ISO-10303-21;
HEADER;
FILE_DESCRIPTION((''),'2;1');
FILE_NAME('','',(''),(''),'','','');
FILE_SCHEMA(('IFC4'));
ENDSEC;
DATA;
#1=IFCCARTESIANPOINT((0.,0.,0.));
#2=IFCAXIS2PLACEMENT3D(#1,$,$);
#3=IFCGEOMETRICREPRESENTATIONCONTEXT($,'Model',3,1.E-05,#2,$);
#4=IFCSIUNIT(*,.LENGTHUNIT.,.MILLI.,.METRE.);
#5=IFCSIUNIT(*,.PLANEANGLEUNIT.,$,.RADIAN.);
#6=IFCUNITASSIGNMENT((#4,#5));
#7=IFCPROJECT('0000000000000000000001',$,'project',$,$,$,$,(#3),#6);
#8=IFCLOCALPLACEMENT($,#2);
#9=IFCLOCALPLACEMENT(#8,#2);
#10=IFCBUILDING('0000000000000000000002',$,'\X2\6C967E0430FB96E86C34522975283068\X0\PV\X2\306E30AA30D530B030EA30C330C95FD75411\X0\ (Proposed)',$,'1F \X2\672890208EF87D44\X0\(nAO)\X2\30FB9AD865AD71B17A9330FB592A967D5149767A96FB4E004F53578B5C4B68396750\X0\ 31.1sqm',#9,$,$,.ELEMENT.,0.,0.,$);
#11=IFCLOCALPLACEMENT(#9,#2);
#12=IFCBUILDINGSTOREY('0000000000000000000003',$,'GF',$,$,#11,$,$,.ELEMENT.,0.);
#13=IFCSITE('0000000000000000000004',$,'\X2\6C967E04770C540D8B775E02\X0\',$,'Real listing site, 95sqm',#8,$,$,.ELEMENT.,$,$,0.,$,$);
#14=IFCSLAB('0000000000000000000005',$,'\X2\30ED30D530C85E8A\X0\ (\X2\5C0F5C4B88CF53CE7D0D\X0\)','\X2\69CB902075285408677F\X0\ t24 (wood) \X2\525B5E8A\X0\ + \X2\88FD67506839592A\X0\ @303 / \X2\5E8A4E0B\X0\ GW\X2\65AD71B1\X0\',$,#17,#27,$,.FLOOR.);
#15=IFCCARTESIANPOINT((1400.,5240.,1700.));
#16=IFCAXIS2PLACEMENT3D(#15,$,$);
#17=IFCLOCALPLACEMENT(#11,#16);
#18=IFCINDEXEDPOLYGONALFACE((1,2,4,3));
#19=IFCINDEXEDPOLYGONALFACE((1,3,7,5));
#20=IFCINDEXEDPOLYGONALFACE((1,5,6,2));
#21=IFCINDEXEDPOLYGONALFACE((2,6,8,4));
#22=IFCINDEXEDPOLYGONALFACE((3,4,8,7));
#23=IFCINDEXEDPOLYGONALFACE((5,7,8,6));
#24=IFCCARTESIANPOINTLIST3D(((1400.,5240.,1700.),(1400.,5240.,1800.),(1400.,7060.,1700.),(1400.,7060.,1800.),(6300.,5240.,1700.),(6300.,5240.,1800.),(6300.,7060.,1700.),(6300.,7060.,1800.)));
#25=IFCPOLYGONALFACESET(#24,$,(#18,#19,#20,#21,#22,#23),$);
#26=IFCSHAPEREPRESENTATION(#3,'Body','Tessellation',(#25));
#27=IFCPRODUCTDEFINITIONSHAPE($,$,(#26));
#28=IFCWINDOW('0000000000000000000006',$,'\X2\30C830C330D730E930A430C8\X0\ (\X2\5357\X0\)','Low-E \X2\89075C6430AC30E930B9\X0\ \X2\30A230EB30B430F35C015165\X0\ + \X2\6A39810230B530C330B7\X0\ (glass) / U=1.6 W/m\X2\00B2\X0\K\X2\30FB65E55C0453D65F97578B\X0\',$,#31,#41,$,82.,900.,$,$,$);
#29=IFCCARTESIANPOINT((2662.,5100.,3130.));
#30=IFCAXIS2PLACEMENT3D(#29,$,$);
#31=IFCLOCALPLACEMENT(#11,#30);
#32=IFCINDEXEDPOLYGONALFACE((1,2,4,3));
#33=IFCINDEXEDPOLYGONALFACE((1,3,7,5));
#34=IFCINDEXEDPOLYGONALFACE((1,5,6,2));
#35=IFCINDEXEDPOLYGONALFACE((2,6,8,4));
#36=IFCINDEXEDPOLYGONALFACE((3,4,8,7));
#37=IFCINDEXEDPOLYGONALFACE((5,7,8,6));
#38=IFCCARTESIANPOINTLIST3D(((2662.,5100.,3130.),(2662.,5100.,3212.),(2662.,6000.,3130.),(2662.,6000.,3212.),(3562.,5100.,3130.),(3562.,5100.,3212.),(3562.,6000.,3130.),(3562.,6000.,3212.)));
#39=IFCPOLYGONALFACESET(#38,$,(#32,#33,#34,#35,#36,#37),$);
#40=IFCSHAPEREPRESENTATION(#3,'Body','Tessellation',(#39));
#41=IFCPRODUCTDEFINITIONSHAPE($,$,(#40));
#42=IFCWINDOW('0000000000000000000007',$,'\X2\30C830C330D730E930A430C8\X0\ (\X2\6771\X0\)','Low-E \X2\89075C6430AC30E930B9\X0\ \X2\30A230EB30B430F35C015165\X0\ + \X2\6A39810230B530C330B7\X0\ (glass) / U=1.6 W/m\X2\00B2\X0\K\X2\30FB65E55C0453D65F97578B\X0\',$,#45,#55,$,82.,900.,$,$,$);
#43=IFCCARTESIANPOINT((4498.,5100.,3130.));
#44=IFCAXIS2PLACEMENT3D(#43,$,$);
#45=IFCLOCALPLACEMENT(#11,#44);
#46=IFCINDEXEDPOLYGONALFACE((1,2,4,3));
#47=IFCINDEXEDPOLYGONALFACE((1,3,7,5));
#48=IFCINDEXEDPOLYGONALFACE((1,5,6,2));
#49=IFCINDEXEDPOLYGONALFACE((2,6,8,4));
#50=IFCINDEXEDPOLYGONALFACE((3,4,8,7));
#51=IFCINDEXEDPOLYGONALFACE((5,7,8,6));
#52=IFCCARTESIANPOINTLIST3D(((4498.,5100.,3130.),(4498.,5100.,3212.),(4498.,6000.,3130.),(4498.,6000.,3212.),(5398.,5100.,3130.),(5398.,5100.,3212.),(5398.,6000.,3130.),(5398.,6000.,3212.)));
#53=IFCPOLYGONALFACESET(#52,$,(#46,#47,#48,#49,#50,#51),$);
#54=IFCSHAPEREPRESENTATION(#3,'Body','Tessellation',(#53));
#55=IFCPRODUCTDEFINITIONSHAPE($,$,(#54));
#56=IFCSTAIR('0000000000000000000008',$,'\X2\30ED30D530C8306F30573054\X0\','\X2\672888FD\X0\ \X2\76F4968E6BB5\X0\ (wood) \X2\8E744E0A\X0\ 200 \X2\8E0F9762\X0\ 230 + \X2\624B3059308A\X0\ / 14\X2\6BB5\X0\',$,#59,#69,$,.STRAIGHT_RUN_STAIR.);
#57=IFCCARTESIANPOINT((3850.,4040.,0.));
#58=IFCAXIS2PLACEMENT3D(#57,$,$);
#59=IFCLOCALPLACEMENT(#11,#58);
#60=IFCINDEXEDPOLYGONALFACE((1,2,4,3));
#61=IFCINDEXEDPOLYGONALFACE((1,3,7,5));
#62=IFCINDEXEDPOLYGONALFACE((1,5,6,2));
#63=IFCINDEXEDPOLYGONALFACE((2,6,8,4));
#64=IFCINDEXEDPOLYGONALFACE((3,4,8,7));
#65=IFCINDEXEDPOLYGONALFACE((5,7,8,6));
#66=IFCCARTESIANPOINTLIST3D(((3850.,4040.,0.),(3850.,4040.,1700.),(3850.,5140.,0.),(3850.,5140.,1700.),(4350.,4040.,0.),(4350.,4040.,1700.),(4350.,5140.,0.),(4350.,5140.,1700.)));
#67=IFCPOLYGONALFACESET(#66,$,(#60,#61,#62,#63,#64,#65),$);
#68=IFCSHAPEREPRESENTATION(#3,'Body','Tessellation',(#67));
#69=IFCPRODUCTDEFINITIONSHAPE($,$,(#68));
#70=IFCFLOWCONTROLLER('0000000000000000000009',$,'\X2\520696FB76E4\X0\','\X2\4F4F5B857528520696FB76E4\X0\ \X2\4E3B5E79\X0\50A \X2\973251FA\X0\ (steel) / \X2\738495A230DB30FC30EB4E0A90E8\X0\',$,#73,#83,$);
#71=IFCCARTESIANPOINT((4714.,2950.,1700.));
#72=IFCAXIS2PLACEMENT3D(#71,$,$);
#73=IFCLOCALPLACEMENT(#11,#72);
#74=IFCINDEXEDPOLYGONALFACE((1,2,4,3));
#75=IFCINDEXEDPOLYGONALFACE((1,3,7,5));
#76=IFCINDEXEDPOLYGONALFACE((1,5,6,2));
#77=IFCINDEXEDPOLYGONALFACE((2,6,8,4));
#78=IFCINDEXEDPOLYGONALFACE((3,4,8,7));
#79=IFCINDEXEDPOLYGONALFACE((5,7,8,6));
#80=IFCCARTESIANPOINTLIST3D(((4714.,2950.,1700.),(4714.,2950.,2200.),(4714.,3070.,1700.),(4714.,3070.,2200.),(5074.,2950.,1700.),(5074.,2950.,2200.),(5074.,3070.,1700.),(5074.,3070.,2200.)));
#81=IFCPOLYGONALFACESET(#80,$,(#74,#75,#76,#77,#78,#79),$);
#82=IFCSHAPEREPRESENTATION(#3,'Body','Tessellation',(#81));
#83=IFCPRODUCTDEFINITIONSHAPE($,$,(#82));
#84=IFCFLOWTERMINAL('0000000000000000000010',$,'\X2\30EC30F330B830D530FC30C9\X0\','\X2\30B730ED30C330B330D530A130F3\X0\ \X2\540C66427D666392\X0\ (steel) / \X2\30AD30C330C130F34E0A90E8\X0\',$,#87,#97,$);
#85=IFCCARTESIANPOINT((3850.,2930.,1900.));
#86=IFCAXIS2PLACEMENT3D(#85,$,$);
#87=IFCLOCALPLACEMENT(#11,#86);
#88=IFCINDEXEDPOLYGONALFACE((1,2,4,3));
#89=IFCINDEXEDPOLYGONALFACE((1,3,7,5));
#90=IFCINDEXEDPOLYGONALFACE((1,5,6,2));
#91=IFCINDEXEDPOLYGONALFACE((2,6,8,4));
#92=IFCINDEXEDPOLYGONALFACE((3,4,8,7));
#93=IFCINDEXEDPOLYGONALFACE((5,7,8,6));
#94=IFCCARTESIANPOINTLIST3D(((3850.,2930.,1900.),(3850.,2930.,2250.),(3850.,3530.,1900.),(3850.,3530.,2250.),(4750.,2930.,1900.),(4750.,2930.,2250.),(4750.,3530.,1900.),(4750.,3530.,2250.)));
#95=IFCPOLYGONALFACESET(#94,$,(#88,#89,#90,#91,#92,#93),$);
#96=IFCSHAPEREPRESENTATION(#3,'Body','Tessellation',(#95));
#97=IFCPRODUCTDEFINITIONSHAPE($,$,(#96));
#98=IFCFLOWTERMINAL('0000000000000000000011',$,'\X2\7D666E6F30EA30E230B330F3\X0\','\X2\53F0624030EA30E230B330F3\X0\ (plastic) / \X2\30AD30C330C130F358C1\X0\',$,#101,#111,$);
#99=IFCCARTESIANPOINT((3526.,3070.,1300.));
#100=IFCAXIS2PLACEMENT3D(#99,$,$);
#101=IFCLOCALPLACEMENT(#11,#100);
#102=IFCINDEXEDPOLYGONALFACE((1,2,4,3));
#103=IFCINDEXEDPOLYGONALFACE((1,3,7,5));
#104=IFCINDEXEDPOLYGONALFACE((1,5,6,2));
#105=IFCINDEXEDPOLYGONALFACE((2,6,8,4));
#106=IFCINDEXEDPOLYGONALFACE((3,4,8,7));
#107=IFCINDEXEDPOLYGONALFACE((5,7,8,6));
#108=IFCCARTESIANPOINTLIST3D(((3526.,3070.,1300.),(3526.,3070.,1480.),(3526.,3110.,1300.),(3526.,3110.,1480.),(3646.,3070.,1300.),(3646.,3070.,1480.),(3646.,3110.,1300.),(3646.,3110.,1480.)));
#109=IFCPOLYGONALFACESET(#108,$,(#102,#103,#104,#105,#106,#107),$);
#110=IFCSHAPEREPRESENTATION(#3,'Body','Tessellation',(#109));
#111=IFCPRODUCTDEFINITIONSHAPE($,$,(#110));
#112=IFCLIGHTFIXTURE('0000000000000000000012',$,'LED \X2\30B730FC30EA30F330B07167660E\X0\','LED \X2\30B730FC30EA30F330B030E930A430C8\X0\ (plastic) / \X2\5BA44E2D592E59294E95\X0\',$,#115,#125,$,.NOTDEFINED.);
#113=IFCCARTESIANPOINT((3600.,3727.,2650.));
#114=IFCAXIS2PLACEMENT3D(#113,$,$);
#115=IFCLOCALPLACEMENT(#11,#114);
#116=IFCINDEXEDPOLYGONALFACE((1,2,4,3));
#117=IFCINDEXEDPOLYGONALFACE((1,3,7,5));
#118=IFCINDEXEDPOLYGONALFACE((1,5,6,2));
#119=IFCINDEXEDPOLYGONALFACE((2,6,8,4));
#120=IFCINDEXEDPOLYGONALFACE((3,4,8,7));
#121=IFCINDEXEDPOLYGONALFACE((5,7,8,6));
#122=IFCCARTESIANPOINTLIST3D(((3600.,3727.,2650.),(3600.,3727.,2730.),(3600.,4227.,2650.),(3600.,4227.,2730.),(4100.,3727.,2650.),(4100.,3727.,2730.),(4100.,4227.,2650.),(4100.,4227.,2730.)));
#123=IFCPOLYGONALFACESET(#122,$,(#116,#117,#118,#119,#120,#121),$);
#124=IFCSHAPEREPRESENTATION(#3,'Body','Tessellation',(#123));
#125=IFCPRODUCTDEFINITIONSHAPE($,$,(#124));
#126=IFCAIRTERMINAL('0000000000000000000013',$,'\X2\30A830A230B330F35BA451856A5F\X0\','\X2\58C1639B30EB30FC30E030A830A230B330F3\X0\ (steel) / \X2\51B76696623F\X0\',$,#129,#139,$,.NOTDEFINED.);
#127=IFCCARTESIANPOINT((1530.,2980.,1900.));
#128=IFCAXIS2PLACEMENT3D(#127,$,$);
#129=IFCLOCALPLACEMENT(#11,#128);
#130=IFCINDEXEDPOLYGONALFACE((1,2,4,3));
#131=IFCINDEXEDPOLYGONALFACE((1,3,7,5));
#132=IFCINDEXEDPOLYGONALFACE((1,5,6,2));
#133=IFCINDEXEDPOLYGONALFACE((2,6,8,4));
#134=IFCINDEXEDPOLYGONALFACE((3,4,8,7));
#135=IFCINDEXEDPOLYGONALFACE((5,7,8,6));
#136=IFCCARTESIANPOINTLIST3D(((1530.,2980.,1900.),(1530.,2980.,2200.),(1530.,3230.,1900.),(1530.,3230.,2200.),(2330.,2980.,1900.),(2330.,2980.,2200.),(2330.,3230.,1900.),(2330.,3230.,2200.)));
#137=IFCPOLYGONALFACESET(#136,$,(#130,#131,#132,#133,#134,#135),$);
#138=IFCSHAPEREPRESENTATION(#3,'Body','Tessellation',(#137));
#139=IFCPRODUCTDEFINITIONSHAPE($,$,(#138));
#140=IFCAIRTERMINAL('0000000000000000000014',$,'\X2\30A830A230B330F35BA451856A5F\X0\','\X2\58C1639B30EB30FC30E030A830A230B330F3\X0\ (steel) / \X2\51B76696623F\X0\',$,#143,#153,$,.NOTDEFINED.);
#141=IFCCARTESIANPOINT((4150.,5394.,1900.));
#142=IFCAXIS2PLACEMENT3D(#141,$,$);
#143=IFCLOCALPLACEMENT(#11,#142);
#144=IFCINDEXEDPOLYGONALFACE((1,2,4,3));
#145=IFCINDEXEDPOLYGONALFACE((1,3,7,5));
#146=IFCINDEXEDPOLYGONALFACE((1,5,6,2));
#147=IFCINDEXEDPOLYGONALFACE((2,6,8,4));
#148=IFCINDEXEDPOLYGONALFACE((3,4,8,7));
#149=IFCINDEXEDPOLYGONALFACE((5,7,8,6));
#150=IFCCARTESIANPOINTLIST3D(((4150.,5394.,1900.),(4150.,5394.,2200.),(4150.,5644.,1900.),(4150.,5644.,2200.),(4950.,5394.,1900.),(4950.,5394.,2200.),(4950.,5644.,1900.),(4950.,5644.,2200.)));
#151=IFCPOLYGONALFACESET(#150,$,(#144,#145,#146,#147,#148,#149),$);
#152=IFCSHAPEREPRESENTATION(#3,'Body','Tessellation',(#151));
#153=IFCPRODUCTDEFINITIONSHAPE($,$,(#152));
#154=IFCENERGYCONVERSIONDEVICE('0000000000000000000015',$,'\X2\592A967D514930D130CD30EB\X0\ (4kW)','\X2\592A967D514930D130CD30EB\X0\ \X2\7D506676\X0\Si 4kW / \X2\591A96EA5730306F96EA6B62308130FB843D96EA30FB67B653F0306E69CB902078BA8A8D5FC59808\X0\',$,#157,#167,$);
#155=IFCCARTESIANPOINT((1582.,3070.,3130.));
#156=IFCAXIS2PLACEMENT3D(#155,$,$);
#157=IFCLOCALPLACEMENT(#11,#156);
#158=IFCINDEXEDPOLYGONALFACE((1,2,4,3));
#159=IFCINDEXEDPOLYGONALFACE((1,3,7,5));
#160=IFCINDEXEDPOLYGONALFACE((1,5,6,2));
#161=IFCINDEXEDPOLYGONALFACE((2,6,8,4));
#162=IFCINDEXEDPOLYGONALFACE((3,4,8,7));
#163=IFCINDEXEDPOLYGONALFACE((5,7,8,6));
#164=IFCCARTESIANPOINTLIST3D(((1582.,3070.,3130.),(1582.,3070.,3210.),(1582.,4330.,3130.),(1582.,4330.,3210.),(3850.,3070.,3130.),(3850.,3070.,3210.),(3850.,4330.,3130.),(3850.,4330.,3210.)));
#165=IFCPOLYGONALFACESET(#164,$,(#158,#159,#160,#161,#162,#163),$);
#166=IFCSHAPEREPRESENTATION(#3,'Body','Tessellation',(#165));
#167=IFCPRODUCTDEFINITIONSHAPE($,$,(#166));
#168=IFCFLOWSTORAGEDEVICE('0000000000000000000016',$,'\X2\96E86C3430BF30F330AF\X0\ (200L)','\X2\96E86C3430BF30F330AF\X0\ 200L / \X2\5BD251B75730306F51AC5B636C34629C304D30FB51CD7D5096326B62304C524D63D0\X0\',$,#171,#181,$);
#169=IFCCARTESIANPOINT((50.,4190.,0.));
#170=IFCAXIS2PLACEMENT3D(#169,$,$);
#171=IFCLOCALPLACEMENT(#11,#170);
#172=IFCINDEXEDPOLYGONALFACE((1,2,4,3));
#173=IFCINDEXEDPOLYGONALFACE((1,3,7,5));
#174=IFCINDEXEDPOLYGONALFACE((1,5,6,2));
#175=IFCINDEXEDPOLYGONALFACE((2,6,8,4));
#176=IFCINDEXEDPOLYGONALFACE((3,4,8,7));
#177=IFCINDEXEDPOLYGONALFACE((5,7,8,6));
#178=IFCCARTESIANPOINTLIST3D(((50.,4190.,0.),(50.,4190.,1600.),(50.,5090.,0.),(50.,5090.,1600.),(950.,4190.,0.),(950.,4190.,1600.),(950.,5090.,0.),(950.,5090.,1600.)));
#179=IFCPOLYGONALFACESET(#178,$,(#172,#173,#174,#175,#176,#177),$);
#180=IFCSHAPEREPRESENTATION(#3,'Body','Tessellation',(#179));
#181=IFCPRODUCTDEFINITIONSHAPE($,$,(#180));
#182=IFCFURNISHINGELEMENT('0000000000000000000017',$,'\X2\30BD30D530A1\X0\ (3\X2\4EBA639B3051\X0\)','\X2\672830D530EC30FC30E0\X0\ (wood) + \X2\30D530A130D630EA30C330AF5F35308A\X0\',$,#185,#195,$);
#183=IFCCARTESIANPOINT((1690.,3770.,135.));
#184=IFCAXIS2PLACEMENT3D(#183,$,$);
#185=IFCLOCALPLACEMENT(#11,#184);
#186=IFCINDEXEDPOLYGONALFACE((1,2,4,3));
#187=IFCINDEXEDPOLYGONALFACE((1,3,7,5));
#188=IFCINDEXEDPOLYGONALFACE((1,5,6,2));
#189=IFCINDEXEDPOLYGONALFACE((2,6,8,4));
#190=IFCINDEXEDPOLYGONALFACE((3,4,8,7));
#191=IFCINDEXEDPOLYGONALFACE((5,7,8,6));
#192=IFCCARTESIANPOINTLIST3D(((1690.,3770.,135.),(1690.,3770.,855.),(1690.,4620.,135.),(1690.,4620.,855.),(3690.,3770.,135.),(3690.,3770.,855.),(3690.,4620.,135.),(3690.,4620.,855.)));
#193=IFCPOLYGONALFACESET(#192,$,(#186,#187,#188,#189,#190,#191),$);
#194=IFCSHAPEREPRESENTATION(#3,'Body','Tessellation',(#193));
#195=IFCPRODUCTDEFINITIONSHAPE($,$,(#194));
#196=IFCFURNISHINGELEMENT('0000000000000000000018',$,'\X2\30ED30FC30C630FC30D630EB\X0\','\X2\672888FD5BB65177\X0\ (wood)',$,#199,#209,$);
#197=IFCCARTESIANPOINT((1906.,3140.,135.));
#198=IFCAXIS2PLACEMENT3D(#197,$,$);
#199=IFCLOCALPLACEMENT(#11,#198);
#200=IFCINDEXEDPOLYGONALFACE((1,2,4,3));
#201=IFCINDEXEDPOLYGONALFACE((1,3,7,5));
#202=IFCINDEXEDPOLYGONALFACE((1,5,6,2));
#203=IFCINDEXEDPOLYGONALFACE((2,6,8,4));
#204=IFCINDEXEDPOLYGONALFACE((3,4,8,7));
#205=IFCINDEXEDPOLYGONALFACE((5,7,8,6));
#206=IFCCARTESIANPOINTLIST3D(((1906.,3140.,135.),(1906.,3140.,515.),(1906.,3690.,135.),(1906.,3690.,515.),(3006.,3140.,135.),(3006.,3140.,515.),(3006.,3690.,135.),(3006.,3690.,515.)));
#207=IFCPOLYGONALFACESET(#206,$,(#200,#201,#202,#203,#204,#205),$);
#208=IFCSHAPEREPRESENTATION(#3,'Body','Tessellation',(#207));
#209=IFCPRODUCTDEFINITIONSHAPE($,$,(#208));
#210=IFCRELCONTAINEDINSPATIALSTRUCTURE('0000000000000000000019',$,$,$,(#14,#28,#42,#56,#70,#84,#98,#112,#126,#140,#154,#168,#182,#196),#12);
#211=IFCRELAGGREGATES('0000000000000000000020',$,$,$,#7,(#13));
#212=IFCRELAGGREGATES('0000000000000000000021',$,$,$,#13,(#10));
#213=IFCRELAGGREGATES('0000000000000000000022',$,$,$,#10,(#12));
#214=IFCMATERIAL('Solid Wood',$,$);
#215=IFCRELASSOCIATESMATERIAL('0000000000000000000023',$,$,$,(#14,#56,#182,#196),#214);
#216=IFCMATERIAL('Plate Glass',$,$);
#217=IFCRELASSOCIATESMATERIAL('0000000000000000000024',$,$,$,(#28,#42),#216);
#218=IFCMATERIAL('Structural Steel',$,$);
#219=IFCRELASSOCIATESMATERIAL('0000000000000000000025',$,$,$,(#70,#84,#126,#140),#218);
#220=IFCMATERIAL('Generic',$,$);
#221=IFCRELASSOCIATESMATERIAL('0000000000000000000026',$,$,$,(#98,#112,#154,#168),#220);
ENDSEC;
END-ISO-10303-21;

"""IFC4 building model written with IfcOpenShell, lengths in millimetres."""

from ifc_helpers import new_model, si_unit, frame, frame_2d, origin, place, context, project, spatial, rectangle, extrude, material, element, save


model = new_model("IFC4")

# Units and contexts
model_context = context("Model", 3, precision=1e-05, world=origin())
ifc_project = project(units=[si_unit("LENGTHUNIT", "METRE", prefix="MILLI"), si_unit("PLANEANGLEUNIT", "RADIAN")], contexts=[model_context])

# Site, building, storey
site_placement = place(None, origin())
site = spatial("IfcSite", under=ifc_project, at=site_placement, Name="沖縄県名護市", ObjectType="Real listing site, 95sqm", CompositionType="ELEMENT", RefElevation=0.0)
building_placement = place(site_placement, origin())
building = spatial("IfcBuilding", under=site, at=building_placement, Name="沖縄・雨水利用とPVのオフグリッド志向 (Proposed)", ObjectType="1F 木造軸組(nAO)・高断熱窓・太陽光発電一体型屋根材 31.1sqm", CompositionType="ELEMENT", ElevationOfRefHeight=0.0, ElevationOfTerrain=0.0)
storey_placement = place(building_placement, origin())
storey = spatial("IfcBuildingStorey", under=building, at=storey_placement, Name="GF", CompositionType="ELEMENT", Elevation=0.0)

# Shared definitions
ifc_material_1 = material(Name="Solid Wood")

# Slab
slab_placement = place(storey_placement, frame((1400.0, 5240.0, 1700.0)))
element("IfcSlab", 1, at=slab_placement, inside=storey, material=ifc_material_1, Name="ロフト床 (小屋裏収納)", Description="構造用合板 t24 (wood) 剛床 + 製材根太 @303 / 床下 GW断熱", PredefinedType="FLOOR", context=model_context, shape_type="SweptSolid", body=[
    extrude(rectangle(XDim=4900.0, YDim=1820.0, at=frame_2d((2450.0, 910.0))), frame((1400.0, 5240.0, 1700.0)), (0.0, 0.0, 1.0), 100.0),
])

# Windows
ifc_material_2 = material(Name="Plate Glass")
window_1_placement = place(storey_placement, frame((2662.0, 5100.0, 3130.0)))
element("IfcWindow", 2, at=window_1_placement, inside=storey, material=ifc_material_2, Name="トップライト (南)", Description="Low-E 複層ガラス アルゴン封入 + 樹脂サッシ (glass) / U=1.6 W/m²K・日射取得型", OverallHeight=82.0, OverallWidth=900.0, context=model_context, shape_type="SweptSolid", body=[
    extrude(rectangle(XDim=900.0, YDim=900.0, at=frame_2d((450.0, 450.0))), frame((2662.0, 5100.0, 3130.0)), (0.0, 0.0, 1.0), 82.0),
])
window_2_placement = place(storey_placement, frame((4498.0, 5100.0, 3130.0)))
element("IfcWindow", 3, at=window_2_placement, inside=storey, material=ifc_material_2, Name="トップライト (東)", Description="Low-E 複層ガラス アルゴン封入 + 樹脂サッシ (glass) / U=1.6 W/m²K・日射取得型", OverallHeight=82.0, OverallWidth=900.0, context=model_context, shape_type="SweptSolid", body=[
    extrude(rectangle(XDim=900.0, YDim=900.0, at=frame_2d((450.0, 450.0))), frame((4498.0, 5100.0, 3130.0)), (0.0, 0.0, 1.0), 82.0),
])

# Stair
stair_placement = place(storey_placement, frame((3850.0, 4040.0, 0.0)))
element("IfcStair", 4, at=stair_placement, inside=storey, material=ifc_material_1, Name="ロフトはしご", Description="木製 直階段 (wood) 蹴上 200 踏面 230 + 手すり / 14段", PredefinedType="STRAIGHT_RUN_STAIR", context=model_context, shape_type="SweptSolid", body=[
    extrude(rectangle(XDim=500.0, YDim=1100.0, at=frame_2d((250.0, 550.0))), frame((3850.0, 4040.0, 0.0)), (0.0, 0.0, 1.0), 1700.0),
])

# Flow controller
ifc_material_3 = material(Name="Structural Steel")
flow_controller_placement = place(storey_placement, frame((4714.0, 2950.0, 1700.0)))
element("IfcFlowController", 5, at=flow_controller_placement, inside=storey, material=ifc_material_3, Name="分電盤", Description="住宅用分電盤 主幹50A 露出 (steel) / 玄関ホール上部", context=model_context, shape_type="SweptSolid", body=[
    extrude(rectangle(XDim=360.0, YDim=120.0, at=frame_2d((180.0, 60.0))), frame((4714.0, 2950.0, 1700.0)), (0.0, 0.0, 1.0), 500.0),
])

# Flow terminals
flow_terminal_1_placement = place(storey_placement, frame((3850.0, 2930.0, 1900.0)))
element("IfcFlowTerminal", 6, at=flow_terminal_1_placement, inside=storey, material=ifc_material_3, Name="レンジフード", Description="シロッコファン 同時給排 (steel) / キッチン上部", context=model_context, shape_type="SweptSolid", body=[
    extrude(rectangle(XDim=900.0, YDim=600.0, at=frame_2d((450.0, 300.0))), frame((3850.0, 2930.0, 1900.0)), (0.0, 0.0, 1.0), 350.0),
])
ifc_material_4 = material(Name="Generic")
flow_terminal_2_placement = place(storey_placement, frame((3526.0, 3070.0, 1300.0)))
element("IfcFlowTerminal", 7, at=flow_terminal_2_placement, inside=storey, material=ifc_material_4, Name="給湯リモコン", Description="台所リモコン (plastic) / キッチン壁", context=model_context, shape_type="SweptSolid", body=[
    extrude(rectangle(XDim=120.0, YDim=40.0, at=frame_2d((60.0, 20.0))), frame((3526.0, 3070.0, 1300.0)), (0.0, 0.0, 1.0), 180.0),
])

# Light fixture
light_fixture_placement = place(storey_placement, frame((3600.0, 3727.0, 2650.0)))
element("IfcLightFixture", 8, at=light_fixture_placement, inside=storey, material=ifc_material_4, Name="LED シーリング照明", Description="LED シーリングライト (plastic) / 室中央天井", PredefinedType="NOTDEFINED", context=model_context, shape_type="SweptSolid", body=[
    extrude(rectangle(XDim=500.0, YDim=500.0, at=frame_2d((250.0, 250.0))), frame((3600.0, 3727.0, 2650.0)), (0.0, 0.0, 1.0), 80.0),
])

# Air terminals
air_terminal_1_placement = place(storey_placement, frame((1530.0, 2980.0, 1900.0)))
element("IfcAirTerminal", 9, at=air_terminal_1_placement, inside=storey, material=ifc_material_3, Name="エアコン室内機", Description="壁掛ルームエアコン (steel) / 冷暖房", PredefinedType="NOTDEFINED", context=model_context, shape_type="SweptSolid", body=[
    extrude(rectangle(XDim=800.0, YDim=250.0, at=frame_2d((400.0, 125.0))), frame((1530.0, 2980.0, 1900.0)), (0.0, 0.0, 1.0), 300.0),
])
air_terminal_2_placement = place(storey_placement, frame((4150.0, 5394.0, 1900.0)))
element("IfcAirTerminal", 10, at=air_terminal_2_placement, inside=storey, material=ifc_material_3, Name="エアコン室内機", Description="壁掛ルームエアコン (steel) / 冷暖房", PredefinedType="NOTDEFINED", context=model_context, shape_type="SweptSolid", body=[
    extrude(rectangle(XDim=800.0, YDim=250.0, at=frame_2d((400.0, 125.0))), frame((4150.0, 5394.0, 1900.0)), (0.0, 0.0, 1.0), 300.0),
])

# Energy conversion device
energy_conversion_device_placement = place(storey_placement, frame((1582.0, 3070.0, 3130.0)))
element("IfcEnergyConversionDevice", 11, at=energy_conversion_device_placement, inside=storey, material=ifc_material_4, Name="太陽光パネル (4kW)", Description="太陽光パネル 結晶Si 4kW / 多雪地は雪止め・落雪・架台の構造確認必須", context=model_context, shape_type="SweptSolid", body=[
    extrude(rectangle(XDim=2268.0, YDim=1260.0, at=frame_2d((1134.0, 630.0))), frame((1582.0, 3070.0, 3130.0)), (0.0, 0.0, 1.0), 80.0),
])

# Flow storage device
flow_storage_device_placement = place(storey_placement, frame((50.0, 4190.0, 0.0)))
element("IfcFlowStorageDevice", 12, at=flow_storage_device_placement, inside=storey, material=ifc_material_4, Name="雨水タンク (200L)", Description="雨水タンク 200L / 寒冷地は冬季水抜き・凍結防止が前提", context=model_context, shape_type="SweptSolid", body=[
    extrude(rectangle(XDim=900.0, YDim=900.0, at=frame_2d((450.0, 450.0))), frame((50.0, 4190.0, 0.0)), (0.0, 0.0, 1.0), 1600.0),
])

# Furnishing elements
furnishing_1_placement = place(storey_placement, frame((1690.0, 3770.0, 135.0)))
element("IfcFurnishingElement", 13, at=furnishing_1_placement, inside=storey, material=ifc_material_1, Name="ソファ (3人掛け)", Description="木フレーム (wood) + ファブリック張り", context=model_context, shape_type="SweptSolid", body=[
    extrude(rectangle(XDim=2000.0, YDim=850.0, at=frame_2d((1000.0, 425.0))), frame((1690.0, 3770.0, 135.0)), (0.0, 0.0, 1.0), 720.0),
])
furnishing_2_placement = place(storey_placement, frame((1906.0, 3140.0, 135.0)))
element("IfcFurnishingElement", 14, at=furnishing_2_placement, inside=storey, material=ifc_material_1, Name="ローテーブル", Description="木製家具 (wood)", context=model_context, shape_type="SweptSolid", body=[
    extrude(rectangle(XDim=1100.0, YDim=550.0, at=frame_2d((550.0, 275.0))), frame((1906.0, 3140.0, 135.0)), (0.0, 0.0, 1.0), 380.0),
])

save(model, "model.ifc")
